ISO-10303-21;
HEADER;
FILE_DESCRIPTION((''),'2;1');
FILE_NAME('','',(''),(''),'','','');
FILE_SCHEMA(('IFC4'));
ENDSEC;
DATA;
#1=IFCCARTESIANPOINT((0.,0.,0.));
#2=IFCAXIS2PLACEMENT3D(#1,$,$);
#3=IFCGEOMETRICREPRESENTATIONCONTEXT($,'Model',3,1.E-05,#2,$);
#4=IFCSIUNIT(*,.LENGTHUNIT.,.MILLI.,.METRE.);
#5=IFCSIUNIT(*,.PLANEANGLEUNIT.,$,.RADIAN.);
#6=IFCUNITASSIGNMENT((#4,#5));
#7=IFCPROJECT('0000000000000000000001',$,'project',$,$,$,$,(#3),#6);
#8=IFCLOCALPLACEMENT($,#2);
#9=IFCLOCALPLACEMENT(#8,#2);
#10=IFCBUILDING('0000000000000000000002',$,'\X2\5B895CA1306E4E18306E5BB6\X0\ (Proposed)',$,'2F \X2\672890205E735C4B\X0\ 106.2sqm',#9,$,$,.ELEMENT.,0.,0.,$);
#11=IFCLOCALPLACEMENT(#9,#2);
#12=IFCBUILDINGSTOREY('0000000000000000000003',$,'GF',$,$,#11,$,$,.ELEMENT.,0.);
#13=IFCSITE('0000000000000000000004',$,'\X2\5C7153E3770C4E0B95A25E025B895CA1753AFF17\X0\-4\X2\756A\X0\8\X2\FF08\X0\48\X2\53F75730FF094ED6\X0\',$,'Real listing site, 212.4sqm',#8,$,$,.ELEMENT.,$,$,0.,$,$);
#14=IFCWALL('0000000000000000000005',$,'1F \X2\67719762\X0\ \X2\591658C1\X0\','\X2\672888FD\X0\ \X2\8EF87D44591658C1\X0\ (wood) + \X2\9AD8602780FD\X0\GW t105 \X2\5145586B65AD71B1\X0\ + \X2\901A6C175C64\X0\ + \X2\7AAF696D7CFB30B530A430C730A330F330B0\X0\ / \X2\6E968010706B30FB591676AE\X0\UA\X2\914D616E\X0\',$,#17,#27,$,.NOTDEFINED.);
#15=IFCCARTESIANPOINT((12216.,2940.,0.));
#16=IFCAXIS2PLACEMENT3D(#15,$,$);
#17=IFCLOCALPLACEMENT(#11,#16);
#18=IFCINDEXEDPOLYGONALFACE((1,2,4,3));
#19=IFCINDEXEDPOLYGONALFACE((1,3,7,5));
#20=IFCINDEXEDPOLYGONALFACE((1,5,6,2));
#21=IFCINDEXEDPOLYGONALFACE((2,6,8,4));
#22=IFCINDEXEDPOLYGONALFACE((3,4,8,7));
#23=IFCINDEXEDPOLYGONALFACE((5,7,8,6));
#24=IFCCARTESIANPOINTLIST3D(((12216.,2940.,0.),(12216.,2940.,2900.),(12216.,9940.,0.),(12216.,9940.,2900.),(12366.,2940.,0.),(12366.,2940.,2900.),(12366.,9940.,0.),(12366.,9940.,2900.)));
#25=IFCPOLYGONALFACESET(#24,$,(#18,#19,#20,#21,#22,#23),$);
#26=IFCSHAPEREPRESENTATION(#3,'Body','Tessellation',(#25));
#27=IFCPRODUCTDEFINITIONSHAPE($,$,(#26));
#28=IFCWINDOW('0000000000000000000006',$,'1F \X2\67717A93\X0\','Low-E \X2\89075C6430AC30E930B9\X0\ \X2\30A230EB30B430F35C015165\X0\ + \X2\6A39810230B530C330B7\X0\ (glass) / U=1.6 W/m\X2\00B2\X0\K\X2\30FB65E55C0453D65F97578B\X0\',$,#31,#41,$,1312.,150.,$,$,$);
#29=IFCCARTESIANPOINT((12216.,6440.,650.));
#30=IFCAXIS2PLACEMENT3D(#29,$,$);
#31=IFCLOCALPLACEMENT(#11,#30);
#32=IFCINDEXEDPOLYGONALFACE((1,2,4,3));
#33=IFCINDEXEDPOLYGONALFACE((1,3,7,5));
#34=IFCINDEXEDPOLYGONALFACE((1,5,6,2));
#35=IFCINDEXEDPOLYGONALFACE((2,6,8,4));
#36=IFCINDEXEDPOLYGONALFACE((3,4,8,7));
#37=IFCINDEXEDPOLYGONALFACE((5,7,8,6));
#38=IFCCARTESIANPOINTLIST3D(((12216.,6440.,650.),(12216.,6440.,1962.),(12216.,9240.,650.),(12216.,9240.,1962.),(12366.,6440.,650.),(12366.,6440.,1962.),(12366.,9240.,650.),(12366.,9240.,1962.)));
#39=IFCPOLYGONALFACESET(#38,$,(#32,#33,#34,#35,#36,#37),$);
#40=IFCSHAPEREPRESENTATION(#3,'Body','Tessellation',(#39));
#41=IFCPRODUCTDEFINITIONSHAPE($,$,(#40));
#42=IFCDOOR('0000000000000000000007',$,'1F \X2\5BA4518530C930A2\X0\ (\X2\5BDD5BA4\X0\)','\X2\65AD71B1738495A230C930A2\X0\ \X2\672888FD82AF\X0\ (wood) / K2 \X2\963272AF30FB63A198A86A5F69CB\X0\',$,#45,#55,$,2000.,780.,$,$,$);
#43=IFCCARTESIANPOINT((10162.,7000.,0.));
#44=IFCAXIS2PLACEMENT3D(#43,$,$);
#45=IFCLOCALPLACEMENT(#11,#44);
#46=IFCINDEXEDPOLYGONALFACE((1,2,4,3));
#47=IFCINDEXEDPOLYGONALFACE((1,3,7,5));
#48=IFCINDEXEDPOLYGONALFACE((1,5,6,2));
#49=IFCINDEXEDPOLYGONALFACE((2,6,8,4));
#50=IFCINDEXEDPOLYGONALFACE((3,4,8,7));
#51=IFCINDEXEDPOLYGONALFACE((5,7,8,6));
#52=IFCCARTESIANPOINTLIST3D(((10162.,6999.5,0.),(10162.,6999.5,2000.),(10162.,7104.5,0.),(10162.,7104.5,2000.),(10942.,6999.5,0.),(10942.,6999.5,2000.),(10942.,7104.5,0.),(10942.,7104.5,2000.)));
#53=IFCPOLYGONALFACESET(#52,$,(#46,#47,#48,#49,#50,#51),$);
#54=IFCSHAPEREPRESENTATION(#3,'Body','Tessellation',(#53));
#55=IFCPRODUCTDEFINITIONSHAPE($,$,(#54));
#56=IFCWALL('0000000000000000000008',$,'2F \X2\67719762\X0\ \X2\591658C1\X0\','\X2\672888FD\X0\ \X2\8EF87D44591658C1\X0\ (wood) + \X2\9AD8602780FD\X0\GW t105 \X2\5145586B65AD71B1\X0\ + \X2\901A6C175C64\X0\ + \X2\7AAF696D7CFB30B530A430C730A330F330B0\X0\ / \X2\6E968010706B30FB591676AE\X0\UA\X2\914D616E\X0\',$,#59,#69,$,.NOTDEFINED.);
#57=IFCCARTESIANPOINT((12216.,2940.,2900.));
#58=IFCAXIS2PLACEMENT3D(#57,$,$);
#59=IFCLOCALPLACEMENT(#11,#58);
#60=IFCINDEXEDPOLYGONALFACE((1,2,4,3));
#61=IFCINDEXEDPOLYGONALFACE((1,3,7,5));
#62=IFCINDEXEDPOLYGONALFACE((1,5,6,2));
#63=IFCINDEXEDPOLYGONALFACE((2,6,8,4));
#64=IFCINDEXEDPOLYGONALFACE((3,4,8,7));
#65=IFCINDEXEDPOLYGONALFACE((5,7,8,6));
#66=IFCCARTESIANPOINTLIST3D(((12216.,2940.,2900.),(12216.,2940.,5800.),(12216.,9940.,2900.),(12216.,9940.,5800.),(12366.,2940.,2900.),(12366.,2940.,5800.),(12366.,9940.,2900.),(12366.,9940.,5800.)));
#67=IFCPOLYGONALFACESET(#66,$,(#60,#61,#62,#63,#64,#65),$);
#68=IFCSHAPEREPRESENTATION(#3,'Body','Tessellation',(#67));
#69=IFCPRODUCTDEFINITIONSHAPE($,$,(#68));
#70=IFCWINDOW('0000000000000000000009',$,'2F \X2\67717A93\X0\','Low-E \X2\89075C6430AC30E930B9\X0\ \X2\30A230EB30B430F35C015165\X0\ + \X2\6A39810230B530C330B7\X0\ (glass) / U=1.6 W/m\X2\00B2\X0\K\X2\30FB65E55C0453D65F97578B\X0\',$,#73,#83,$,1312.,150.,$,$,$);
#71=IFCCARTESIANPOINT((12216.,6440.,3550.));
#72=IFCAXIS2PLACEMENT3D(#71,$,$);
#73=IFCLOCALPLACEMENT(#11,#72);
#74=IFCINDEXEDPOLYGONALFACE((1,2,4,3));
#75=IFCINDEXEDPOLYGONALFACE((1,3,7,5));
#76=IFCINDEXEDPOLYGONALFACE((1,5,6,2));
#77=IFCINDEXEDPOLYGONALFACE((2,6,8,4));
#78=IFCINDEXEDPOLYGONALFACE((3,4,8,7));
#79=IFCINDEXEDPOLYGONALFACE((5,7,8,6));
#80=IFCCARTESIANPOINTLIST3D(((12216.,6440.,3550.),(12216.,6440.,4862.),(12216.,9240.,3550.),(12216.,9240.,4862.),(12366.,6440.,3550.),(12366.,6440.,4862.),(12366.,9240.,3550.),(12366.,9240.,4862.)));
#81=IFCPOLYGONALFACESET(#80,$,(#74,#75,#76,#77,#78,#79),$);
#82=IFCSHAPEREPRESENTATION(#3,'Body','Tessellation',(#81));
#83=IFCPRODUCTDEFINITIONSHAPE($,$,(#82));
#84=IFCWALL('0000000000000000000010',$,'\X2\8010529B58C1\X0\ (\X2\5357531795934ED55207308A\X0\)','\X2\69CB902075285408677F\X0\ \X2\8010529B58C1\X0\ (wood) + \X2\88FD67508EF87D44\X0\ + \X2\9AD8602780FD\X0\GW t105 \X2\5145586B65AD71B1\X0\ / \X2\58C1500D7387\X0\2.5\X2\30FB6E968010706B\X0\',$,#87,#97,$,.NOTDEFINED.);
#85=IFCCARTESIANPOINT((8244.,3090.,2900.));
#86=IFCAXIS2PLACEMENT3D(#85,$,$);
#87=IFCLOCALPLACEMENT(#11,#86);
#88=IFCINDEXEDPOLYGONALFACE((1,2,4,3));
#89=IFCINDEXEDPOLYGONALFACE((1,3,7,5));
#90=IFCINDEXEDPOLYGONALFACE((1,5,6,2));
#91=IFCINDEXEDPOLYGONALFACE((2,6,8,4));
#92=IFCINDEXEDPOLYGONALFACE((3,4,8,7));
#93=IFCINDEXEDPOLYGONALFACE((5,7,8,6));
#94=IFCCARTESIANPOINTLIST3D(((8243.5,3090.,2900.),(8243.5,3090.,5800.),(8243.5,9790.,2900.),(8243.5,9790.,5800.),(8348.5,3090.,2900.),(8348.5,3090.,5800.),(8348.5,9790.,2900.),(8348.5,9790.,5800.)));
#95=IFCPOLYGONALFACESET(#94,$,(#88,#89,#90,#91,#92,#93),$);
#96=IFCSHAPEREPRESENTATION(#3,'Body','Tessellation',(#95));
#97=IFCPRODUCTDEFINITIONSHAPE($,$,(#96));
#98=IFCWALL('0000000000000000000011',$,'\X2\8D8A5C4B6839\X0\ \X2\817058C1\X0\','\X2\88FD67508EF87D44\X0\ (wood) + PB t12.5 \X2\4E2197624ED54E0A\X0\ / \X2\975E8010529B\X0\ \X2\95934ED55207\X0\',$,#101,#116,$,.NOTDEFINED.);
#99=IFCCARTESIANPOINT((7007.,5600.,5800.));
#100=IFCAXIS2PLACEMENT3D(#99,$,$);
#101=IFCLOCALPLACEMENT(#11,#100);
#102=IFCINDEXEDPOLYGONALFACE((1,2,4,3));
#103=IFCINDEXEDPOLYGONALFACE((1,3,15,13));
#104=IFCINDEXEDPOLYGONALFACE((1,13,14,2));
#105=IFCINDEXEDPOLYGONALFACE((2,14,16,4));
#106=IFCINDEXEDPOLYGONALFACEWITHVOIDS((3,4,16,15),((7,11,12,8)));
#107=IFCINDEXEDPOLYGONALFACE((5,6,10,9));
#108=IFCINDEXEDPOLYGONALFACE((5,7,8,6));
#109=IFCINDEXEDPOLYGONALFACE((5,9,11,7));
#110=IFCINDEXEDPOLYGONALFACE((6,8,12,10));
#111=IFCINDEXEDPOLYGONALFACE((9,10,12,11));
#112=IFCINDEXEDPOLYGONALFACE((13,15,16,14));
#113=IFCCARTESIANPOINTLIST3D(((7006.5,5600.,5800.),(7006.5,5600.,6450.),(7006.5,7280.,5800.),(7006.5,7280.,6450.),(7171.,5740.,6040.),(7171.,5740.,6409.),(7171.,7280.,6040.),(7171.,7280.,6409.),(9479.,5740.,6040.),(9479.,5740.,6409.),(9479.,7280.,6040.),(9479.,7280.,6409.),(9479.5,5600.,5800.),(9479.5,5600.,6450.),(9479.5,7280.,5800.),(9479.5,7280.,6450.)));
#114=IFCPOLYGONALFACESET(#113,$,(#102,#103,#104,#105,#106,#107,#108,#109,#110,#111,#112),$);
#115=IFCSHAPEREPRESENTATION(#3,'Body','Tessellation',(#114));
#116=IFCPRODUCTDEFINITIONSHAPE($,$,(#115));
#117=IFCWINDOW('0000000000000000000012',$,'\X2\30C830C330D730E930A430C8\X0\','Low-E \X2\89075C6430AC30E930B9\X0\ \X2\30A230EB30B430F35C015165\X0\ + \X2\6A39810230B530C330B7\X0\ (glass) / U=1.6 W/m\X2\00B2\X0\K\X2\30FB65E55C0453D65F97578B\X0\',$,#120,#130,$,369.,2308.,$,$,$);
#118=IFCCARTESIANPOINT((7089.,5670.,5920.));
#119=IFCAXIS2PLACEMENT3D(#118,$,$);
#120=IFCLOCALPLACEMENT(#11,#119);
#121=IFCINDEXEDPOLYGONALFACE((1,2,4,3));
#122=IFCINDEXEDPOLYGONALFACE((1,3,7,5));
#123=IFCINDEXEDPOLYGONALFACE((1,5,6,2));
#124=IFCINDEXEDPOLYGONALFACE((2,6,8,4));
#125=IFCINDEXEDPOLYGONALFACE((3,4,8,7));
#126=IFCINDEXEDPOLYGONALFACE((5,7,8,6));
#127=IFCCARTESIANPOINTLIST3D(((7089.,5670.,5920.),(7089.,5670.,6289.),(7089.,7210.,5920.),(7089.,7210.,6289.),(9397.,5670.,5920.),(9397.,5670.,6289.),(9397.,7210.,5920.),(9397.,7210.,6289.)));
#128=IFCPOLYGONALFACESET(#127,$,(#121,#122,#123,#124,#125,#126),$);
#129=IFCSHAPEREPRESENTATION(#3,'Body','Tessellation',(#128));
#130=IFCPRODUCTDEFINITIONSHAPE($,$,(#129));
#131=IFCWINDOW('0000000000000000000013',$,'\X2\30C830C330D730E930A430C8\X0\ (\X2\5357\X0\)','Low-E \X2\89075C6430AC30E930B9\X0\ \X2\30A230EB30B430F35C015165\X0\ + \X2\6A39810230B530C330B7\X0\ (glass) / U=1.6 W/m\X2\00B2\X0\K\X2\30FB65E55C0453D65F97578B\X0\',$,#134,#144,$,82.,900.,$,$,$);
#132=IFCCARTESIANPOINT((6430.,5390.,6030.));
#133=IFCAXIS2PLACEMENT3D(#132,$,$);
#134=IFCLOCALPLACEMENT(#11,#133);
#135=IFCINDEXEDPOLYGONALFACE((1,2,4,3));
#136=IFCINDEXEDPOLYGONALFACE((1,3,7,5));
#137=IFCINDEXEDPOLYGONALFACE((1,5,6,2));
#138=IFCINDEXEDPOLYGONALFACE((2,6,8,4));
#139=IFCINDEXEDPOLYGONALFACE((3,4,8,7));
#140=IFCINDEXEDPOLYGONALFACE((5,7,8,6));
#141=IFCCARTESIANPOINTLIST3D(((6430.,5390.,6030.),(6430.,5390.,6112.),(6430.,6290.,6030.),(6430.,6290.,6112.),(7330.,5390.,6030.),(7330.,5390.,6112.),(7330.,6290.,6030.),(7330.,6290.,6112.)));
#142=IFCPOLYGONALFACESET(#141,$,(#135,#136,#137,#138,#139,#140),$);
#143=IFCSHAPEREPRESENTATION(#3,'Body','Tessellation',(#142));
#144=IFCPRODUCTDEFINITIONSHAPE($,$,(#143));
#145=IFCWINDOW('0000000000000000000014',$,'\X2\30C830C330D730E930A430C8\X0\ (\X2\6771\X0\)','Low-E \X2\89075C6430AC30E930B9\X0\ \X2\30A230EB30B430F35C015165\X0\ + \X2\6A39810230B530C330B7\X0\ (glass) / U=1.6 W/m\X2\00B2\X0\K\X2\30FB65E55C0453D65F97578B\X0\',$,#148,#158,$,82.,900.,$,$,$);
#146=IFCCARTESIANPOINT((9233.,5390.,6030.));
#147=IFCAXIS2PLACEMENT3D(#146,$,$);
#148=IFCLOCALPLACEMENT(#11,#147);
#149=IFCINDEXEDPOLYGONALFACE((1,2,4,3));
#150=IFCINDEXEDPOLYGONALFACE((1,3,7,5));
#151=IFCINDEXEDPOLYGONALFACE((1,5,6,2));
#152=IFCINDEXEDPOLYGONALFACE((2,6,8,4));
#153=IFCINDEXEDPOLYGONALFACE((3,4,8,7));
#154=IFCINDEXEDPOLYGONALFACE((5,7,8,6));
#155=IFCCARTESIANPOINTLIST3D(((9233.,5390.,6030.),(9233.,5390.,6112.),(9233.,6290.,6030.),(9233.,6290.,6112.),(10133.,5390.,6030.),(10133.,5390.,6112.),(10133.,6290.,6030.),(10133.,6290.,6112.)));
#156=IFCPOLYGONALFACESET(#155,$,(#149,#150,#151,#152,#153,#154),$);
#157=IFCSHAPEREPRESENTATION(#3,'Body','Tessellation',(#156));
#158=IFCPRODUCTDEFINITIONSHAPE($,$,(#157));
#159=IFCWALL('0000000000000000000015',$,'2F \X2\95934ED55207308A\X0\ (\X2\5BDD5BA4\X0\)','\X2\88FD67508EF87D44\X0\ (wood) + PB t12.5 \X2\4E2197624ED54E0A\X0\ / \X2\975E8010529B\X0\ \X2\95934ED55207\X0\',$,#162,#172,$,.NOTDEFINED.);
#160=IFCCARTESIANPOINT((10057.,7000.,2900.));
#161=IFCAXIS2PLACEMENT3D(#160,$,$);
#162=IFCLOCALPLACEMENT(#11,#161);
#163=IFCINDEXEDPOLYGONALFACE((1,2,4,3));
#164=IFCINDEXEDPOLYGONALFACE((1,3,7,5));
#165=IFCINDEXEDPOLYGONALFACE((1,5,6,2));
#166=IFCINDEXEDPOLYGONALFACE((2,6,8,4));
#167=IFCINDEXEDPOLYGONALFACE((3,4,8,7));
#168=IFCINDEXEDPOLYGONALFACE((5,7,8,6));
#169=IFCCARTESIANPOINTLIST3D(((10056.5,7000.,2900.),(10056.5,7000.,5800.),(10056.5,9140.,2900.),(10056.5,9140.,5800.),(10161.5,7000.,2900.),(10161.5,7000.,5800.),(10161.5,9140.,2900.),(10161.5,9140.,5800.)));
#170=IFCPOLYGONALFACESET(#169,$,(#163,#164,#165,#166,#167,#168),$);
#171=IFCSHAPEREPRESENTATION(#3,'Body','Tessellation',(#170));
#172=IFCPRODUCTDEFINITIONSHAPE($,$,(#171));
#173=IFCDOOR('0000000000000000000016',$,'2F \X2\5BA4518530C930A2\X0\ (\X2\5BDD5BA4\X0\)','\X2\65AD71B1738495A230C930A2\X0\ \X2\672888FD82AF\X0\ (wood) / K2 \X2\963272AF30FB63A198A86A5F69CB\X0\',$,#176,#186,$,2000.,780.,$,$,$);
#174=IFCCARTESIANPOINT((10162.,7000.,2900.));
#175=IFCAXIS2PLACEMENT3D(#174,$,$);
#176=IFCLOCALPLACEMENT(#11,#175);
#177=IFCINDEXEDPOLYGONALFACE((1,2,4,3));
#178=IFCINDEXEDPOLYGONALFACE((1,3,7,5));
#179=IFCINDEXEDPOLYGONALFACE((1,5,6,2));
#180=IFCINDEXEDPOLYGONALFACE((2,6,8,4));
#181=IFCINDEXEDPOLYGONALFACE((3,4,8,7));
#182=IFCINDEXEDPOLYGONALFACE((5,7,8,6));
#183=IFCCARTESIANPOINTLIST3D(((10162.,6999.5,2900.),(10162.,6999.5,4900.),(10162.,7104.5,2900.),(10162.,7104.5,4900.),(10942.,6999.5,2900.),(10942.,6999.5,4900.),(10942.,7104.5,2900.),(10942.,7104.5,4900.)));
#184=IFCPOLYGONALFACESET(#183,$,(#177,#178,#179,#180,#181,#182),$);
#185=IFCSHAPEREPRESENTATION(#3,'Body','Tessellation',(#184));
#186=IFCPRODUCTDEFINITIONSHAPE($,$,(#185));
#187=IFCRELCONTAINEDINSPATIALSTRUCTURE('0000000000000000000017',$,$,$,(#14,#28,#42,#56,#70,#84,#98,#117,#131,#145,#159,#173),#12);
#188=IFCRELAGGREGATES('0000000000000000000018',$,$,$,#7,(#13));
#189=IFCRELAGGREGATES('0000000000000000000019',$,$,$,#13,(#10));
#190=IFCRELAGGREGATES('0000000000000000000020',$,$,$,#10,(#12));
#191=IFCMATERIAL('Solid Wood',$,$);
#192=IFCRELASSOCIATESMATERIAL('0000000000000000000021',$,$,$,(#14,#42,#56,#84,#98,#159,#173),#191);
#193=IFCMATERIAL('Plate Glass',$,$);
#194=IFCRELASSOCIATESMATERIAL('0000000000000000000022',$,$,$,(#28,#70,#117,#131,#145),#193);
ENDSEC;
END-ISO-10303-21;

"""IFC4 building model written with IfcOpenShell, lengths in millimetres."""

from ifc_helpers import new_model, si_unit, frame, frame_2d, origin, place, context, project, spatial, rectangle, extrude, material, element, fill, save


model = new_model("IFC4")

# Units and contexts
model_context = context("Model", 3, precision=1e-05, world=origin())
ifc_project = project(units=[si_unit("LENGTHUNIT", "METRE", prefix="MILLI"), si_unit("PLANEANGLEUNIT", "RADIAN")], contexts=[model_context])

# Site, building, storey
site_placement = place(None, origin())
site = spatial("IfcSite", under=ifc_project, at=site_placement, Name="山口県下関市安岡町７-4番8（48号地）他", ObjectType="Real listing site, 212.4sqm", CompositionType="ELEMENT", RefElevation=0.0)
building_placement = place(site_placement, origin())
building = spatial("IfcBuilding", under=site, at=building_placement, Name="安岡の丘の家 (Proposed)", ObjectType="2F 木造平屋 106.2sqm", CompositionType="ELEMENT", ElevationOfRefHeight=0.0, ElevationOfTerrain=0.0)
storey_placement = place(building_placement, origin())
storey = spatial("IfcBuildingStorey", under=building, at=storey_placement, Name="GF", CompositionType="ELEMENT", Elevation=0.0)

# Wall, opening, window
ifc_material_1 = material(Name="Solid Wood")
wall_1_placement = place(storey_placement, frame((12216.0, 2940.0, 0.0)))
wall_1 = element("IfcWall", 1, at=wall_1_placement, inside=storey, material=ifc_material_1, Name="1F 東面 外壁", Description="木製 軸組外壁 (wood) + 高性能GW t105 充填断熱 + 通気層 + 窯業系サイディング / 準耐火・外皮UA配慮", PredefinedType="NOTDEFINED", context=model_context, shape_type="SweptSolid", body=[
    extrude(rectangle(XDim=150.0, YDim=7000.0, at=frame_2d((75.0, 3500.0))), frame((12216.0, 2940.0, 0.0)), (0.0, 0.0, 1.0), 2900.0),
])
opening_1_placement = place(storey_placement, frame((12216.0, 6440.0, 650.0)))
opening_1 = element("IfcOpeningElement", 2, at=opening_1_placement, cuts=wall_1, PredefinedType="NOTDEFINED", context=model_context, shape_type="SweptSolid", body=[
    extrude(rectangle(XDim=150.0, YDim=2800.0, at=frame_2d((75.0, 1400.0))), frame((12216.0, 6440.0, 650.0)), (0.0, 0.0, 1.0), 1312.0),
])
ifc_material_2 = material(Name="Plate Glass")
window_1_placement = place(storey_placement, frame((12216.0, 6440.0, 650.0)))
window_1 = element("IfcWindow", 3, at=window_1_placement, inside=storey, material=ifc_material_2, Name="1F 東窓", Description="Low-E 複層ガラス アルゴン封入 + 樹脂サッシ (glass) / U=1.6 W/m²K・日射取得型", OverallHeight=1312.0, OverallWidth=150.0, context=model_context, shape_type="SweptSolid", body=[
    extrude(rectangle(XDim=150.0, YDim=2800.0, at=frame_2d((75.0, 1400.0))), frame((12216.0, 6440.0, 650.0)), (0.0, 0.0, 1.0), 1312.0),
])
fill(opening_1, window_1)

# Door
door_1_placement = place(storey_placement, frame((10162.0, 7000.0, 0.0)))
element("IfcDoor", 4, at=door_1_placement, inside=storey, material=ifc_material_1, Name="1F 室内ドア (寝室)", Description="断熱玄関ドア 木製芯 (wood) / K2 防犯・採風機構", OverallHeight=2000.0, OverallWidth=780.0, context=model_context, shape_type="SweptSolid", body=[
    extrude(rectangle(XDim=780.0, YDim=105.0, at=frame_2d((390.0, 52.0))), frame((10162.0, 7000.0, 0.0)), (0.0, 0.0, 1.0), 2000.0),
])

# Wall, opening, window
wall_2_placement = place(storey_placement, frame((12216.0, 2940.0, 2900.0)))
wall_2 = element("IfcWall", 5, at=wall_2_placement, inside=storey, material=ifc_material_1, Name="2F 東面 外壁", Description="木製 軸組外壁 (wood) + 高性能GW t105 充填断熱 + 通気層 + 窯業系サイディング / 準耐火・外皮UA配慮", PredefinedType="NOTDEFINED", context=model_context, shape_type="SweptSolid", body=[
    extrude(rectangle(XDim=150.0, YDim=7000.0, at=frame_2d((75.0, 3500.0))), frame((12216.0, 2940.0, 2900.0)), (0.0, 0.0, 1.0), 2900.0),
])
opening_2_placement = place(storey_placement, frame((12216.0, 6440.0, 3550.0)))
opening_2 = element("IfcOpeningElement", 6, at=opening_2_placement, cuts=wall_2, PredefinedType="NOTDEFINED", context=model_context, shape_type="SweptSolid", body=[
    extrude(rectangle(XDim=150.0, YDim=2800.0, at=frame_2d((75.0, 1400.0))), frame((12216.0, 6440.0, 3550.0)), (0.0, 0.0, 1.0), 1312.0),
])
window_2_placement = place(storey_placement, frame((12216.0, 6440.0, 3550.0)))
window_2 = element("IfcWindow", 7, at=window_2_placement, inside=storey, material=ifc_material_2, Name="2F 東窓", Description="Low-E 複層ガラス アルゴン封入 + 樹脂サッシ (glass) / U=1.6 W/m²K・日射取得型", OverallHeight=1312.0, OverallWidth=150.0, context=model_context, shape_type="SweptSolid", body=[
    extrude(rectangle(XDim=150.0, YDim=2800.0, at=frame_2d((75.0, 1400.0))), frame((12216.0, 6440.0, 3550.0)), (0.0, 0.0, 1.0), 1312.0),
])
fill(opening_2, window_2)

# Wall
wall_3_placement = place(storey_placement, frame((8244.0, 3090.0, 2900.0)))
element("IfcWall", 8, at=wall_3_placement, inside=storey, material=ifc_material_1, Name="耐力壁 (南北間仕切り)", Description="構造用合板 耐力壁 (wood) + 製材軸組 + 高性能GW t105 充填断熱 / 壁倍率2.5・準耐火", PredefinedType="NOTDEFINED", context=model_context, shape_type="SweptSolid", body=[
    extrude(rectangle(XDim=105.0, YDim=6700.0, at=frame_2d((52.0, 3350.0))), frame((8244.0, 3090.0, 2900.0)), (0.0, 0.0, 1.0), 2900.0),
])

# Wall, openings, windows
wall_4_placement = place(storey_placement, frame((7007.0, 5600.0, 5800.0)))
wall_4 = element("IfcWall", 9, at=wall_4_placement, inside=storey, material=ifc_material_1, Name="越屋根 腰壁", Description="製材軸組 (wood) + PB t12.5 両面仕上 / 非耐力 間仕切", PredefinedType="NOTDEFINED", context=model_context, shape_type="SweptSolid", body=[
    extrude(rectangle(XDim=2473.0, YDim=1680.0, at=frame_2d((1236.0, 840.0))), frame((7007.0, 5600.0, 5800.0)), (0.0, 0.0, 1.0), 650.0),
])
opening_3_placement = place(storey_placement, frame((7089.0, 5670.0, 5920.0)))
opening_3 = element("IfcOpeningElement", 10, at=opening_3_placement, cuts=wall_4, PredefinedType="NOTDEFINED", context=model_context, shape_type="SweptSolid", body=[
    extrude(rectangle(XDim=2308.0, YDim=1540.0, at=frame_2d((1154.0, 770.0))), frame((7089.0, 5670.0, 5920.0)), (0.0, 0.0, 1.0), 369.0),
])
opening_4_placement = place(storey_placement, frame((6430.0, 5390.0, 6030.0)))
opening_4 = element("IfcOpeningElement", 11, at=opening_4_placement, cuts=wall_4, PredefinedType="NOTDEFINED", context=model_context, shape_type="SweptSolid", body=[
    extrude(rectangle(XDim=900.0, YDim=900.0, at=frame_2d((450.0, 450.0))), frame((6430.0, 5390.0, 6030.0)), (0.0, 0.0, 1.0), 82.0),
])
opening_5_placement = place(storey_placement, frame((9233.0, 5390.0, 6030.0)))
opening_5 = element("IfcOpeningElement", 12, at=opening_5_placement, cuts=wall_4, PredefinedType="NOTDEFINED", context=model_context, shape_type="SweptSolid", body=[
    extrude(rectangle(XDim=900.0, YDim=900.0, at=frame_2d((450.0, 450.0))), frame((9233.0, 5390.0, 6030.0)), (0.0, 0.0, 1.0), 82.0),
])
window_3_placement = place(storey_placement, frame((7089.0, 5670.0, 5920.0)))
window_3 = element("IfcWindow", 13, at=window_3_placement, inside=storey, material=ifc_material_2, Name="トップライト", Description="Low-E 複層ガラス アルゴン封入 + 樹脂サッシ (glass) / U=1.6 W/m²K・日射取得型", OverallHeight=369.0, OverallWidth=2308.0, context=model_context, shape_type="SweptSolid", body=[
    extrude(rectangle(XDim=2308.0, YDim=1540.0, at=frame_2d((1154.0, 770.0))), frame((7089.0, 5670.0, 5920.0)), (0.0, 0.0, 1.0), 369.0),
])
fill(opening_3, window_3)
window_4_placement = place(storey_placement, frame((6430.0, 5390.0, 6030.0)))
window_4 = element("IfcWindow", 14, at=window_4_placement, inside=storey, material=ifc_material_2, Name="トップライト (南)", Description="Low-E 複層ガラス アルゴン封入 + 樹脂サッシ (glass) / U=1.6 W/m²K・日射取得型", OverallHeight=82.0, OverallWidth=900.0, context=model_context, shape_type="SweptSolid", body=[
    extrude(rectangle(XDim=900.0, YDim=900.0, at=frame_2d((450.0, 450.0))), frame((6430.0, 5390.0, 6030.0)), (0.0, 0.0, 1.0), 82.0),
])
fill(opening_4, window_4)
window_5_placement = place(storey_placement, frame((9233.0, 5390.0, 6030.0)))
window_5 = element("IfcWindow", 15, at=window_5_placement, inside=storey, material=ifc_material_2, Name="トップライト (東)", Description="Low-E 複層ガラス アルゴン封入 + 樹脂サッシ (glass) / U=1.6 W/m²K・日射取得型", OverallHeight=82.0, OverallWidth=900.0, context=model_context, shape_type="SweptSolid", body=[
    extrude(rectangle(XDim=900.0, YDim=900.0, at=frame_2d((450.0, 450.0))), frame((9233.0, 5390.0, 6030.0)), (0.0, 0.0, 1.0), 82.0),
])
fill(opening_5, window_5)

# Wall
wall_5_placement = place(storey_placement, frame((10057.0, 7000.0, 2900.0)))
element("IfcWall", 16, at=wall_5_placement, inside=storey, material=ifc_material_1, Name="2F 間仕切り (寝室)", Description="製材軸組 (wood) + PB t12.5 両面仕上 / 非耐力 間仕切", PredefinedType="NOTDEFINED", context=model_context, shape_type="SweptSolid", body=[
    extrude(rectangle(XDim=105.0, YDim=2140.0, at=frame_2d((52.0, 1070.0))), frame((10057.0, 7000.0, 2900.0)), (0.0, 0.0, 1.0), 2900.0),
])

# Door
door_2_placement = place(storey_placement, frame((10162.0, 7000.0, 2900.0)))
element("IfcDoor", 17, at=door_2_placement, inside=storey, material=ifc_material_1, Name="2F 室内ドア (寝室)", Description="断熱玄関ドア 木製芯 (wood) / K2 防犯・採風機構", OverallHeight=2000.0, OverallWidth=780.0, context=model_context, shape_type="SweptSolid", body=[
    extrude(rectangle(XDim=780.0, YDim=105.0, at=frame_2d((390.0, 52.0))), frame((10162.0, 7000.0, 2900.0)), (0.0, 0.0, 1.0), 2000.0),
])

save(model, "model.ifc")
